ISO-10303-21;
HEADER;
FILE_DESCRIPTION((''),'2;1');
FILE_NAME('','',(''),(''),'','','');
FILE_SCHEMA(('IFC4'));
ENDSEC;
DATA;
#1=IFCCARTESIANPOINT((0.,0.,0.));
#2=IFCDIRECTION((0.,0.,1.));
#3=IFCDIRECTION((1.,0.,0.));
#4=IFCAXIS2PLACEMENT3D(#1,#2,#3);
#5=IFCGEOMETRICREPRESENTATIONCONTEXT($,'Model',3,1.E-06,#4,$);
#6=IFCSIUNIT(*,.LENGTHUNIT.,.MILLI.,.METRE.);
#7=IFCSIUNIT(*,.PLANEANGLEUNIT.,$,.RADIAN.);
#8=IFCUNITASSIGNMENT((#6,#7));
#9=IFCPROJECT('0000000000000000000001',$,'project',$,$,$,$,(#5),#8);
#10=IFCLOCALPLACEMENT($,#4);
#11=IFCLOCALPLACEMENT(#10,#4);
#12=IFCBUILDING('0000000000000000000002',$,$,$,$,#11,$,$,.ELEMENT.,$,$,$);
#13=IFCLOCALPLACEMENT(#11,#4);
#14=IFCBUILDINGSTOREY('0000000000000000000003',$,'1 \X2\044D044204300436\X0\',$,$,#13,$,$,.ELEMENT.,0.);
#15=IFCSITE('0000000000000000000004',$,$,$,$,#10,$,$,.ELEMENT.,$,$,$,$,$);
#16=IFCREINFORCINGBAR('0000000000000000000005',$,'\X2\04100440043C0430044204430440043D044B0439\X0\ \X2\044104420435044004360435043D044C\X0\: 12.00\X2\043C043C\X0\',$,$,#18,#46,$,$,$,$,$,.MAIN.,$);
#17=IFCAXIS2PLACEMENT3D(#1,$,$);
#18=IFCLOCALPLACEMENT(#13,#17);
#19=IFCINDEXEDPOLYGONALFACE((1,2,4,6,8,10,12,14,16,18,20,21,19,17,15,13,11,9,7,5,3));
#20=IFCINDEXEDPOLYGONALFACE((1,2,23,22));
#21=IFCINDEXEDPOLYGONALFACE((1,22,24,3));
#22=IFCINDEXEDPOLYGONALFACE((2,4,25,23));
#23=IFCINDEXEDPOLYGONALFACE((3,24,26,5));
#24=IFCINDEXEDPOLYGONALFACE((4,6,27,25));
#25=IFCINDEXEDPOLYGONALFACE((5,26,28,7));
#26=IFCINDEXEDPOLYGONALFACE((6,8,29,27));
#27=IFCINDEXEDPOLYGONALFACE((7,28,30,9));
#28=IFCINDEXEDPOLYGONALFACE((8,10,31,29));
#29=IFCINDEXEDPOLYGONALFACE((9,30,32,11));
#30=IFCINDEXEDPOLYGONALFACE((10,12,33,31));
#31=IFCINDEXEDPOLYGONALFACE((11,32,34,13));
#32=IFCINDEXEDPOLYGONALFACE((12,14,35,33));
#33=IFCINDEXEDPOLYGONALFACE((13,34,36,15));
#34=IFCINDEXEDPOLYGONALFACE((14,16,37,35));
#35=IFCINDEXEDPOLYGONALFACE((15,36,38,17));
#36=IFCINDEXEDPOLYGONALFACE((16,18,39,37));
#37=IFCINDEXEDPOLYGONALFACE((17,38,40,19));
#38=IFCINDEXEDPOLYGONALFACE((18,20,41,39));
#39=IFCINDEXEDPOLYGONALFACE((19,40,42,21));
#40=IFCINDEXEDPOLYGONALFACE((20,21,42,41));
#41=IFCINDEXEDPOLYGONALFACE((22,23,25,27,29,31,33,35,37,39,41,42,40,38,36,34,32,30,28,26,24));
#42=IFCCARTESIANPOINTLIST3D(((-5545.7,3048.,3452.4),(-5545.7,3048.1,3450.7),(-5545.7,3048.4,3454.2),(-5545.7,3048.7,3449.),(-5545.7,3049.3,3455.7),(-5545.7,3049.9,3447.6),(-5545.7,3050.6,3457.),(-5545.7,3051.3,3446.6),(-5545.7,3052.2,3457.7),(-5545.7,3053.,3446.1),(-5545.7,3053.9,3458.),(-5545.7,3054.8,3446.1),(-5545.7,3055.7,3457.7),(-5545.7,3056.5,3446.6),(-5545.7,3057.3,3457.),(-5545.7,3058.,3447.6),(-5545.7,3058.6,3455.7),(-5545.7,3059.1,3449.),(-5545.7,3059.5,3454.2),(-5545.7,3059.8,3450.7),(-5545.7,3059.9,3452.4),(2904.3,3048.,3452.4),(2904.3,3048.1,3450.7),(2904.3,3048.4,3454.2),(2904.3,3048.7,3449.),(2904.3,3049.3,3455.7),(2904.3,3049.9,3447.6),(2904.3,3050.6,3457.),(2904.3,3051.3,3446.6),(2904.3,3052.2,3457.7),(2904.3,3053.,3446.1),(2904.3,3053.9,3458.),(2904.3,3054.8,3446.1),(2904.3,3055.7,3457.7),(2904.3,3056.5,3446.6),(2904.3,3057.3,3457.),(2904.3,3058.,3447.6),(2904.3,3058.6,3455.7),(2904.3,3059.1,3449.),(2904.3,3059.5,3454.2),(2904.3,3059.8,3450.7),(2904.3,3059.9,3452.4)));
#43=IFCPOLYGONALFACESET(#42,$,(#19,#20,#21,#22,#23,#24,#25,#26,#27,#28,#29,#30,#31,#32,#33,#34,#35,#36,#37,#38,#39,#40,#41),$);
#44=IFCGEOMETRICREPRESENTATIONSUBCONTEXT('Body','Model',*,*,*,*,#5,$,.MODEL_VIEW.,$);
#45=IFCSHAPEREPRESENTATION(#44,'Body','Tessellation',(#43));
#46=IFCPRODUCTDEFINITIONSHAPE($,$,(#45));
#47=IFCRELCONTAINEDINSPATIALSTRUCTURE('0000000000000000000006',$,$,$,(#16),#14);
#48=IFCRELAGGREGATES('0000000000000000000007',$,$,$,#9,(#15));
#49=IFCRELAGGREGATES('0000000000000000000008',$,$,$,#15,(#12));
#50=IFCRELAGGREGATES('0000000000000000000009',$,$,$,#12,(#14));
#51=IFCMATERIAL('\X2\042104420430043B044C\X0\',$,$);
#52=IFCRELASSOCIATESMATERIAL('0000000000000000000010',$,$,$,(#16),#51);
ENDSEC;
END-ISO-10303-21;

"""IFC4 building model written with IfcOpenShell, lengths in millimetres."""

from ifc_helpers import new_model, entity, si_unit, origin_with_axes, place, context, subcontext, project, spatial, source, transform, mapped, material, element, save


model = new_model("IFC4")

# Units and contexts
model_context = context("Model", 3, precision=1e-06, world=origin_with_axes())
body_context = subcontext(model_context, "Body", "Model", "MODEL_VIEW")
ifc_project = project(units=[si_unit("LENGTHUNIT", "METRE", prefix="MILLI"), si_unit("PLANEANGLEUNIT", "RADIAN")], contexts=[model_context])

# Site, building, storey
site_placement = place(None, origin_with_axes())
site = spatial("IfcSite", under=ifc_project, at=site_placement, CompositionType="ELEMENT")
building_placement = place(site_placement, origin_with_axes())
building = spatial("IfcBuilding", under=site, at=building_placement, CompositionType="ELEMENT")
storey_placement = place(building_placement, origin_with_axes())
storey = spatial("IfcBuildingStorey", under=building, at=storey_placement, Name="1 этаж", CompositionType="ELEMENT", Elevation=0.0)

# Reinforcing bar
ifc_material_1 = material(Name="Сталь")
shared_shape_1 = source(origin_with_axes(), body_context, "Body", "AdvancedSweptSolid", [
    entity("IfcSweptDiskSolid", entity("IfcIndexedPolyCurve", entity("IfcCartesianPointList3D", [[0.0, 0.0, 0.0], [8450.0, 0.0, 0.0]]), [entity("IfcLineIndex", [1, 2])]), 6.0),
])
reinforcing_bar_1_placement = place(storey_placement, origin_with_axes())
element("IfcReinforcingBar", 1, at=reinforcing_bar_1_placement, inside=storey, material=ifc_material_1, Name="Арматурный стержень: 12.00мм", PredefinedType="MAIN", context=body_context, shape_type="MappedRepresentation", body=[
    mapped(shared_shape_1, transform((-5545.7, 3053.9, 3452.0), x_axis=(1.0, 0.0, 0.0), y_axis=(0.0, 1.0, 0.0), z_axis=(0.0, 0.0, 1.0), scale=1.0)),
])

save(model, "model.ifc")
